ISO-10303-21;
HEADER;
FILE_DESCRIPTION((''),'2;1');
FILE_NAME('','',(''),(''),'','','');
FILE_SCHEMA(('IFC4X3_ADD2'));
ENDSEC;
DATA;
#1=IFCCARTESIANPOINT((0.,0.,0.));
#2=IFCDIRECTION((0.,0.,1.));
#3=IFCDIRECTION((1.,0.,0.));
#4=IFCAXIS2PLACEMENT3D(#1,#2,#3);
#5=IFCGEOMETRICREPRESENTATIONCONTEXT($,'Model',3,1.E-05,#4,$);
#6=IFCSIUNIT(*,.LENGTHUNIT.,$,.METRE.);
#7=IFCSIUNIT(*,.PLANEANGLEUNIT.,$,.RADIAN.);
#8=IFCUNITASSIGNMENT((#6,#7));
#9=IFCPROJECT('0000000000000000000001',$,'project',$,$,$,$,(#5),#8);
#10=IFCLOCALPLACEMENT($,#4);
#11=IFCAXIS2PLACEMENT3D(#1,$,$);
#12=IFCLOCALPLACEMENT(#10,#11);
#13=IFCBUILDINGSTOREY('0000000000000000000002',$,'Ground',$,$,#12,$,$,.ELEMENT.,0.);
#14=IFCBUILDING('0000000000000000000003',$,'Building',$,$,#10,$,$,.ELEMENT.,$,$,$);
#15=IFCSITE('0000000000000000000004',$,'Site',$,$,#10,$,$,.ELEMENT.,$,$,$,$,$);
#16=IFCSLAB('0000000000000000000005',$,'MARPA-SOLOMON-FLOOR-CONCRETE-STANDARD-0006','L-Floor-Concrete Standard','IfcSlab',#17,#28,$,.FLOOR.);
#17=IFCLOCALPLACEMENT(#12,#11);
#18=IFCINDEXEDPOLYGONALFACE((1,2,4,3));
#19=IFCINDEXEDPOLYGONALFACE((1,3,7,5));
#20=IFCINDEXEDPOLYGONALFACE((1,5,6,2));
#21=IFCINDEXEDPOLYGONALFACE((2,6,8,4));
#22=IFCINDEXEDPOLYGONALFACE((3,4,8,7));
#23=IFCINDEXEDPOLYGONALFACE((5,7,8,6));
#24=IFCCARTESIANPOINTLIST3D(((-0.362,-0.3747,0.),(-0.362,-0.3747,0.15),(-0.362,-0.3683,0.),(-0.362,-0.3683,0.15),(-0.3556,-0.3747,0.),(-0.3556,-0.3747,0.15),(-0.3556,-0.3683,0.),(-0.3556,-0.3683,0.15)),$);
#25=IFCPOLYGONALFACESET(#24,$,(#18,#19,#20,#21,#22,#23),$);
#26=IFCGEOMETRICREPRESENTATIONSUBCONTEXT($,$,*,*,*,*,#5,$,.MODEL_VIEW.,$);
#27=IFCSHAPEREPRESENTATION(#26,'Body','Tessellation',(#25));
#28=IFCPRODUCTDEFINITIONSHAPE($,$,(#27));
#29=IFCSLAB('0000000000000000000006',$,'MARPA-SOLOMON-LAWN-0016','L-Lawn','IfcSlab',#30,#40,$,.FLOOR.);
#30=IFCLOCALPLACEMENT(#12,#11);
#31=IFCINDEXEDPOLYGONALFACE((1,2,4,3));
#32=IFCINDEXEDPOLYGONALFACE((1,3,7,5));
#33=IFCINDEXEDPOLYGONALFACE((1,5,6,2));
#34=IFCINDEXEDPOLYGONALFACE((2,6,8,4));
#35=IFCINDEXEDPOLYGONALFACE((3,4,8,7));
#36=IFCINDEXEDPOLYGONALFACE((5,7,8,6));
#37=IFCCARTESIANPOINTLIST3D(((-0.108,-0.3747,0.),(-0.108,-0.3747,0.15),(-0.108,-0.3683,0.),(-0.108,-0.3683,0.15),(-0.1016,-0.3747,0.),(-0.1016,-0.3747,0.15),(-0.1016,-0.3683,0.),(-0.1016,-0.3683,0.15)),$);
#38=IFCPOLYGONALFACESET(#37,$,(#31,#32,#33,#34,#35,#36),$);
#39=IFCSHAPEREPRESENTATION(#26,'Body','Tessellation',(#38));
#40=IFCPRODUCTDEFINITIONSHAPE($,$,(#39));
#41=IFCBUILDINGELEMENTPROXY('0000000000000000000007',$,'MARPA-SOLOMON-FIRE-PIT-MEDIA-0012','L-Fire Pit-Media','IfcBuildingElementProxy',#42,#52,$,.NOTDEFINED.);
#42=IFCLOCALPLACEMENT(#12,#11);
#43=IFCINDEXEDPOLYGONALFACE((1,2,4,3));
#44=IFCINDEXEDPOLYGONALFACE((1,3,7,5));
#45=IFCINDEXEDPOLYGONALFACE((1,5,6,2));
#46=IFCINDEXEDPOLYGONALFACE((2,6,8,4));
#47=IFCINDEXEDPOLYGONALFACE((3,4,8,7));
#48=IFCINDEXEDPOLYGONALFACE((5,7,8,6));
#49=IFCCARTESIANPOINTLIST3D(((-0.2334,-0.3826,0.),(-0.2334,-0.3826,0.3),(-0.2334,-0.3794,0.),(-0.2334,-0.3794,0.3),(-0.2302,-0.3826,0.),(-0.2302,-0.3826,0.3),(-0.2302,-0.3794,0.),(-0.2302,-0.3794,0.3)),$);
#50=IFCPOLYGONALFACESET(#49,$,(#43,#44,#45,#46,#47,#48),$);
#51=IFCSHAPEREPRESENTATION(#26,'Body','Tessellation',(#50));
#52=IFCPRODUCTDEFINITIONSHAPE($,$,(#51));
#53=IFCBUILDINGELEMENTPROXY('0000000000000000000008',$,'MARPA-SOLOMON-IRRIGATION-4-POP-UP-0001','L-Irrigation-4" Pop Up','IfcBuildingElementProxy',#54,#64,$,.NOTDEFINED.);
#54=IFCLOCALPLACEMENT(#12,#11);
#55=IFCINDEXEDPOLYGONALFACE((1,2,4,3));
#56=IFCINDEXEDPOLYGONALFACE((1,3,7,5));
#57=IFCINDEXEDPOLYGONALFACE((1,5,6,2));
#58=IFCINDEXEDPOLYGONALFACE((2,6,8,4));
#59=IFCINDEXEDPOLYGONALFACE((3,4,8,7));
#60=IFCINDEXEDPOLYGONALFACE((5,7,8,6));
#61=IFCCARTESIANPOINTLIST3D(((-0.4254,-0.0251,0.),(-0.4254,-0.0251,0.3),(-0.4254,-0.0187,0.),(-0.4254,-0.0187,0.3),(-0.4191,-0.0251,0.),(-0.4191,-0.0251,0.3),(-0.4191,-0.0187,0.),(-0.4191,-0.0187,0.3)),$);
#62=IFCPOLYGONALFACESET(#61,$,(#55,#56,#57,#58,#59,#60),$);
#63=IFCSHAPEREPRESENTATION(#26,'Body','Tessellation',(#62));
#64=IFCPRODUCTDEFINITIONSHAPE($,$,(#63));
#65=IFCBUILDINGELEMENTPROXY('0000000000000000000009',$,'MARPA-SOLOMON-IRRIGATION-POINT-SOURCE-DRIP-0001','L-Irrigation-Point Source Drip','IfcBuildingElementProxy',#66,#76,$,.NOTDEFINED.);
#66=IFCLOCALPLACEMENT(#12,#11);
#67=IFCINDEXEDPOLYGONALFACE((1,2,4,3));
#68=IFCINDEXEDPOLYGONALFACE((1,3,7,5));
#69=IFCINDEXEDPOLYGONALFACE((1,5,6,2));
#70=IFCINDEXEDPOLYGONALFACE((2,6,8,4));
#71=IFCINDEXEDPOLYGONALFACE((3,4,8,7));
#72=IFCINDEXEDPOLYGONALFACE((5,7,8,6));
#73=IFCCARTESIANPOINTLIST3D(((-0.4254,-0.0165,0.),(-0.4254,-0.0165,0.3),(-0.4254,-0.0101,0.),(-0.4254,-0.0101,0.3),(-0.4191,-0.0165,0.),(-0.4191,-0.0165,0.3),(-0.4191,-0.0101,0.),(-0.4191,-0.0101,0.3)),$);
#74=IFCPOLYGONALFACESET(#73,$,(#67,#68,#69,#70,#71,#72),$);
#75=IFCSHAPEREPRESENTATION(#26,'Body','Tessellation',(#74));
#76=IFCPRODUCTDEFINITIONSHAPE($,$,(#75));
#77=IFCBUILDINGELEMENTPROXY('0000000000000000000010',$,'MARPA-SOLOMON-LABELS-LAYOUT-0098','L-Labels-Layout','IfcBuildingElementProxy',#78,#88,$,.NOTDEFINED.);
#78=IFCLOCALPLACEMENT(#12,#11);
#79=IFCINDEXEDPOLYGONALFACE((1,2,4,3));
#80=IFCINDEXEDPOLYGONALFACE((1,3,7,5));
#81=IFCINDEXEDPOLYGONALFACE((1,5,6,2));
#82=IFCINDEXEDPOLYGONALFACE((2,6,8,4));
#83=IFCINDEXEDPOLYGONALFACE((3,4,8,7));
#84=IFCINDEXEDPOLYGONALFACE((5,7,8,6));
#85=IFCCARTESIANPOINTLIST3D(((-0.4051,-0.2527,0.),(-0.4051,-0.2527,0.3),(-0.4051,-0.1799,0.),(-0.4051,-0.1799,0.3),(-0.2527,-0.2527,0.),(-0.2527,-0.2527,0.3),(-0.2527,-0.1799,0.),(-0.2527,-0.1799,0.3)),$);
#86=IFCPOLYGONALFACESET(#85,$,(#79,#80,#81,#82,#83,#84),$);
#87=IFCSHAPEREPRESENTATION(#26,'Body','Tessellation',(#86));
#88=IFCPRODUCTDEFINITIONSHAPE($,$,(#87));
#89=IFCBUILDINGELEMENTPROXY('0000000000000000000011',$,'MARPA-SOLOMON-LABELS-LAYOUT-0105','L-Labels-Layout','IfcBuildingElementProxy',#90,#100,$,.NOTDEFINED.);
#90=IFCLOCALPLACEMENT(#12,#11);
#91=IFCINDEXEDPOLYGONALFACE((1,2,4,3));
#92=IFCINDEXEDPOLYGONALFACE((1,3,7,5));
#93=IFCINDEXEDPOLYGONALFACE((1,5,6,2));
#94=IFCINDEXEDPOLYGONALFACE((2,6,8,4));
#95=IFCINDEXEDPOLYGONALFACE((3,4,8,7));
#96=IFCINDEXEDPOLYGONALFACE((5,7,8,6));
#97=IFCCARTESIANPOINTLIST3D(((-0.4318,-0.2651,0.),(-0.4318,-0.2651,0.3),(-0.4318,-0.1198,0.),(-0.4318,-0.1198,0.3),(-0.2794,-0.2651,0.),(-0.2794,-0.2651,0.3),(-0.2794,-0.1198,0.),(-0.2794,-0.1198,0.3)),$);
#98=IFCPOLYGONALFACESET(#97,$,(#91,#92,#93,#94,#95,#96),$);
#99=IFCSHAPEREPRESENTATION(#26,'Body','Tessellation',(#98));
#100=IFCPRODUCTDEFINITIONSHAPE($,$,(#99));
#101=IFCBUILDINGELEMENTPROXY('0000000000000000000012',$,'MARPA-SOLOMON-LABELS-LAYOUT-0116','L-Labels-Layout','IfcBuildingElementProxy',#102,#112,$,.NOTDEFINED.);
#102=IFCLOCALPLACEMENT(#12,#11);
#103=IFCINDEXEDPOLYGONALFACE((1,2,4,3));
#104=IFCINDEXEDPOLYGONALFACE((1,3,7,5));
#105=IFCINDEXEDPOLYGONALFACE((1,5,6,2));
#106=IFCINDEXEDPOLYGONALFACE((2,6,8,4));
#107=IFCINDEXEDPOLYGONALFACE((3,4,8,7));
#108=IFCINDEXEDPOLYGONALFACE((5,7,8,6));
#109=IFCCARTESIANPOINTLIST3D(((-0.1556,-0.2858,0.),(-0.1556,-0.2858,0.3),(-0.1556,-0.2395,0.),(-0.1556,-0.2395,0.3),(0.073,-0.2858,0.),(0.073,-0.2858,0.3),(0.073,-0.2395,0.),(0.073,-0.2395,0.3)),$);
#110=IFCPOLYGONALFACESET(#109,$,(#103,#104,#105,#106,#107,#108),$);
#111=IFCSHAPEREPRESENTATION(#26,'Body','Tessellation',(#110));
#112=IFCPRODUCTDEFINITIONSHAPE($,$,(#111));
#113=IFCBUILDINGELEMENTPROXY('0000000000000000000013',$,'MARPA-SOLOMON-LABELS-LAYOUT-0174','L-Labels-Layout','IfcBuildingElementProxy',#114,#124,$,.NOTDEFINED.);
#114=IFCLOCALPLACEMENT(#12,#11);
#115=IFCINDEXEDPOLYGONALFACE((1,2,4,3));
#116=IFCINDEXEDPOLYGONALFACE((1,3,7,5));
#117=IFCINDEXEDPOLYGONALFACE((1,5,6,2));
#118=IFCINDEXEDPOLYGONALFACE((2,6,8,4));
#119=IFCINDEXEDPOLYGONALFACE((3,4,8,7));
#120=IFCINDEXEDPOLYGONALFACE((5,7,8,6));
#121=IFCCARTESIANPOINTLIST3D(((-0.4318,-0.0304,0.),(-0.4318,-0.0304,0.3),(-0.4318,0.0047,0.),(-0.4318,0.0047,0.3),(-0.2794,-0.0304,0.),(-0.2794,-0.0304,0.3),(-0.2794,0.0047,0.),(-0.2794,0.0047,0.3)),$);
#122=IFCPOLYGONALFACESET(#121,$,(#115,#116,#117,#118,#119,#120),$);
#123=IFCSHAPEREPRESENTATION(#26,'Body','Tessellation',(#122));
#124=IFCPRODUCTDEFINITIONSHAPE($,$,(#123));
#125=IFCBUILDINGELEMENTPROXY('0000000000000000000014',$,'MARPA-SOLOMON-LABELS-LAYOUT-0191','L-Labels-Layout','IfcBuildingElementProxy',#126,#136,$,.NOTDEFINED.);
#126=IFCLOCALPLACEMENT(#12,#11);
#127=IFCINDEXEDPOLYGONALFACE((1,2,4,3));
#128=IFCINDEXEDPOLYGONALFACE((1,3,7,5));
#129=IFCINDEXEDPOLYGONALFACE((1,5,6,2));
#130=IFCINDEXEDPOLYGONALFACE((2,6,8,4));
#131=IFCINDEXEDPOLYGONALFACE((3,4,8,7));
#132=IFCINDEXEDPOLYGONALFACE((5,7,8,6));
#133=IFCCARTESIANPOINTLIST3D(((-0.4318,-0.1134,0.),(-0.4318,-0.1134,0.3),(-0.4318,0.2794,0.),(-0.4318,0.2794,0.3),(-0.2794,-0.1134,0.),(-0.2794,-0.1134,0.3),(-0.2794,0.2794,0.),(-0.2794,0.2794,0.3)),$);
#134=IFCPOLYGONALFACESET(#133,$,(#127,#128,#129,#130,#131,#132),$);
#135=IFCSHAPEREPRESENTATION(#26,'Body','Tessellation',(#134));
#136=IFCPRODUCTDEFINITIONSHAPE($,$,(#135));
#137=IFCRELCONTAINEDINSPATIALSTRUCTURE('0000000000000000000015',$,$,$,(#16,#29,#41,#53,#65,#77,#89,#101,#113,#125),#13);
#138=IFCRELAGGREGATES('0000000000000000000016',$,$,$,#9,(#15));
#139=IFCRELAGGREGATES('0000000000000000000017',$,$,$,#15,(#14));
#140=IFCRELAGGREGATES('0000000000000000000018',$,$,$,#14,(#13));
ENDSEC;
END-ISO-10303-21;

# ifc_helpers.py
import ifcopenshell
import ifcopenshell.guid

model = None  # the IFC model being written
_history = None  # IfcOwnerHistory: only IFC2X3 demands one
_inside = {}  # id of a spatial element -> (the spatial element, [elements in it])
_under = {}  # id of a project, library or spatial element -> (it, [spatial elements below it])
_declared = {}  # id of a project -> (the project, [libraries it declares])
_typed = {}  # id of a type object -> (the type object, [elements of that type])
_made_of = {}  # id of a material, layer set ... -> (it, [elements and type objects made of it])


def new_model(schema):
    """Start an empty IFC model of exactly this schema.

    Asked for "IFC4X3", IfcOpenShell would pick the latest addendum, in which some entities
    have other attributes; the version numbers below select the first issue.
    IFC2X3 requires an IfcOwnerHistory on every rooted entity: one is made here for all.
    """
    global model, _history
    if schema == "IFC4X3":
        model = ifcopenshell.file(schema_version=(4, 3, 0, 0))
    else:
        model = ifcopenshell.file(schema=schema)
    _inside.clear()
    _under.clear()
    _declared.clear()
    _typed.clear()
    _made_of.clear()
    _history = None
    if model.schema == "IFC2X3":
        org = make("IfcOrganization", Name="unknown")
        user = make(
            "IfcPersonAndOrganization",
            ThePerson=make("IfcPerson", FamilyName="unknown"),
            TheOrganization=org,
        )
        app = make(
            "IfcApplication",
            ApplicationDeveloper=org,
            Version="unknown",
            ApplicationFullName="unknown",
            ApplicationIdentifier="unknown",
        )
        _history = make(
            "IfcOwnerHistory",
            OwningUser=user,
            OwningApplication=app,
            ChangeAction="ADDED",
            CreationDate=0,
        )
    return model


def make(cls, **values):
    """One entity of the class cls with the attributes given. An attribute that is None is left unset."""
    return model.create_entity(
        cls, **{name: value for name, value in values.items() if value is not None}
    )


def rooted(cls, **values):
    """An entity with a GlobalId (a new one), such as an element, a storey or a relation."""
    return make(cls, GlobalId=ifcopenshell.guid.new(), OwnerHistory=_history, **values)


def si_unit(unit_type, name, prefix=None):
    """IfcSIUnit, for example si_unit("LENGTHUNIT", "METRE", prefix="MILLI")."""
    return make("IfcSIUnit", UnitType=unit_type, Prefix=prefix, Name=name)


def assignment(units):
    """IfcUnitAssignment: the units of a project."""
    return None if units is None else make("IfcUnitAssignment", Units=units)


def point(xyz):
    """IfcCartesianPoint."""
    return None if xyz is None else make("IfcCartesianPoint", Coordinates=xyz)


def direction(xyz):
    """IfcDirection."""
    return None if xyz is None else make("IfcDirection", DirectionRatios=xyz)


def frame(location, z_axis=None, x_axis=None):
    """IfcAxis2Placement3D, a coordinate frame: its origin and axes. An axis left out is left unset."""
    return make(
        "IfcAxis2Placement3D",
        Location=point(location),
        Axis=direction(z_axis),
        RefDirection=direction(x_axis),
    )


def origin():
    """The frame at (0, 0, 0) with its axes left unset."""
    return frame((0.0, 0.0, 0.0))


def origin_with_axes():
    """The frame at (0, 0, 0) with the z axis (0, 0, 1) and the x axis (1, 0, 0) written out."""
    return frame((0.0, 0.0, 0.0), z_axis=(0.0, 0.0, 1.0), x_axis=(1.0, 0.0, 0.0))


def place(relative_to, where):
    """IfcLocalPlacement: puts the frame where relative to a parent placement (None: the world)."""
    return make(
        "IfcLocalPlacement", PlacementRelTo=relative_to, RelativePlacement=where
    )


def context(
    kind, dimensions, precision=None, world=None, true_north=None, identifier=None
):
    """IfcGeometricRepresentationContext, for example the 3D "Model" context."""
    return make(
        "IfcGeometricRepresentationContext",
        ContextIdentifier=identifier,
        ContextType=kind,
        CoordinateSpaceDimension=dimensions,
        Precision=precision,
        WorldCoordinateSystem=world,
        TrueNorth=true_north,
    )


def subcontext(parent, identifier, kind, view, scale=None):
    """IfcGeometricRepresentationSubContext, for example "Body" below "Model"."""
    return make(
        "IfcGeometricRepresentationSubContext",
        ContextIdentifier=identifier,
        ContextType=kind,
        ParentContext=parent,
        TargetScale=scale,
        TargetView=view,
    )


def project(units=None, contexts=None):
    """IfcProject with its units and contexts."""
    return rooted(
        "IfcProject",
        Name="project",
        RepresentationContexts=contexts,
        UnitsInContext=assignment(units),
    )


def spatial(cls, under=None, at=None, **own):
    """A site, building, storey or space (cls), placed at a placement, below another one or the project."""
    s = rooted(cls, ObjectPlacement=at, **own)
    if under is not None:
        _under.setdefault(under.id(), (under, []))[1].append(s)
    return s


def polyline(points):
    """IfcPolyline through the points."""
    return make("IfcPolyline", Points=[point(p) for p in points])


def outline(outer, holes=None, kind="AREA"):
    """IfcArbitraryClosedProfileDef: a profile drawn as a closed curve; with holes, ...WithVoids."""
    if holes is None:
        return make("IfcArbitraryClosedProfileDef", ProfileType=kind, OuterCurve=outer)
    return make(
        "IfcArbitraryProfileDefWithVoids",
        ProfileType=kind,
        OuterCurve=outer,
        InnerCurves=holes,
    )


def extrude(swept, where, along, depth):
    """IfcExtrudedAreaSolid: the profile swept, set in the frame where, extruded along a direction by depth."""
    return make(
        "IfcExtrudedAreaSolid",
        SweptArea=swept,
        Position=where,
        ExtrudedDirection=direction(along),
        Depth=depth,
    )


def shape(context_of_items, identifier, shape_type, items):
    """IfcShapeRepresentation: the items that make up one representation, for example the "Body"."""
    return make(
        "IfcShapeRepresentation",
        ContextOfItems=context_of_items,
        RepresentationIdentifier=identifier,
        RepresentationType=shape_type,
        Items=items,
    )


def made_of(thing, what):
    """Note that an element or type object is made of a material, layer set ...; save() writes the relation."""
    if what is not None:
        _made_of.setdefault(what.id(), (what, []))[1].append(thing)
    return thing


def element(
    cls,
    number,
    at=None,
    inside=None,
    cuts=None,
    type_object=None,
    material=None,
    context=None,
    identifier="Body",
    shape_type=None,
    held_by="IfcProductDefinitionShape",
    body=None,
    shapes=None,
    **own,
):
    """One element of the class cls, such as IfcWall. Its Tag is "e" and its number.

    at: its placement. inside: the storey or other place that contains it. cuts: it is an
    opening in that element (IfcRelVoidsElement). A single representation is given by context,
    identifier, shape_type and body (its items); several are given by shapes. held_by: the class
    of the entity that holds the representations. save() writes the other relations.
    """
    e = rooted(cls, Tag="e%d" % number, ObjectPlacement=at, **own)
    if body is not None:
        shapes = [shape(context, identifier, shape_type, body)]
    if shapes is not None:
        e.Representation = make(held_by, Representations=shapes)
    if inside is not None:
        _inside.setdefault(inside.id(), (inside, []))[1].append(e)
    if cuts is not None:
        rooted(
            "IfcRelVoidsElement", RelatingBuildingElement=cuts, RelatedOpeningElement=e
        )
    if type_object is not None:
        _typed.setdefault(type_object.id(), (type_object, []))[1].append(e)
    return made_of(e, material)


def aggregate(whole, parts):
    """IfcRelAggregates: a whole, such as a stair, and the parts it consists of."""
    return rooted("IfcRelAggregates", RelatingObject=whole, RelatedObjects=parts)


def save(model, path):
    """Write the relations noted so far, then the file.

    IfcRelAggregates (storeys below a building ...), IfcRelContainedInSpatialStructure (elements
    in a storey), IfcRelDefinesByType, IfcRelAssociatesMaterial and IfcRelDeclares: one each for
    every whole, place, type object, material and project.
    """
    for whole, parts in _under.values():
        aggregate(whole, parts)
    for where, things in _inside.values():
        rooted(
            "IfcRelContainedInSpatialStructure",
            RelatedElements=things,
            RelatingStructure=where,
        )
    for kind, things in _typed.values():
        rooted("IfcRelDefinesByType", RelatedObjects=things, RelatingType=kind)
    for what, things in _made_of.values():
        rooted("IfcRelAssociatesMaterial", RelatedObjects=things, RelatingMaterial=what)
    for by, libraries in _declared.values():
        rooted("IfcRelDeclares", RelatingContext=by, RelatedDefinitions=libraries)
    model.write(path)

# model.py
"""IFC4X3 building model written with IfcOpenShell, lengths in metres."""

from ifc_helpers import new_model, si_unit, frame, origin, origin_with_axes, place, context, subcontext, project, spatial, polyline, outline, extrude, element, save


model = new_model("IFC4X3")

# Units and contexts
model_context = context("Model", 3, precision=1e-05, world=origin_with_axes())
sub_context = subcontext(model_context, None, None, "MODEL_VIEW")
ifc_project = project(units=[si_unit("LENGTHUNIT", "METRE"), si_unit("PLANEANGLEUNIT", "RADIAN")], contexts=[model_context])

# Site, building, storey
placement = place(None, origin_with_axes())
site = spatial("IfcSite", under=ifc_project, at=placement, Name="Site", CompositionType="ELEMENT")
building = spatial("IfcBuilding", under=site, at=placement, Name="Building", CompositionType="ELEMENT")
storey_placement = place(placement, origin())
storey = spatial("IfcBuildingStorey", under=building, at=storey_placement, Name="Ground", CompositionType="ELEMENT", Elevation=0.0)

# Slabs
for number, where, name, description in (
    (1, (-0.362, -0.3747, 0.0), "MARPA-SOLOMON-FLOOR-CONCRETE-STANDARD-0006", "L-Floor-Concrete Standard"),
    (2, (-0.108, -0.3747, 0.0), "MARPA-SOLOMON-LAWN-0016", "L-Lawn"),
):
    element("IfcSlab", number, at=place(storey_placement, frame(where)), inside=storey, Name=name, Description=description, ObjectType="IfcSlab", PredefinedType="FLOOR", context=sub_context, shape_type="SweptSolid", body=[
        extrude(outline(polyline([(0.0, 0.0064), (0.0063, 0.0064), (0.0063, 0.0), (0.0, 0.0), (0.0, 0.0064)])), origin(), (0.0, 0.0, 1.0), 0.15),
    ])

# Building element proxies
for number, where, name in (
    (3, (-0.2334, -0.3826, 0.0), "MARPA-SOLOMON-FIRE-PIT-MEDIA-0012"),
):
    element("IfcBuildingElementProxy", number, at=place(placement, frame(where)), inside=storey, Name=name, Description="L-Fire Pit-Media", ObjectType="IfcBuildingElementProxy", PredefinedType="NOTDEFINED", context=sub_context, shape_type="SweptSolid", body=[
        extrude(outline(polyline([(0.0, 0.0032), (0.0032, 0.0032), (0.0032, 0.0), (0.0, 0.0), (0.0, 0.0032)])), origin(), (0.0, 0.0, 1.0), 0.3),
    ])
for number, where, name, description in (
    (4, (-0.4254, -0.0251, 0.0), "MARPA-SOLOMON-IRRIGATION-4-POP-UP-0001", "L-Irrigation-4\" Pop Up"),
    (5, (-0.4254, -0.0165, 0.0), "MARPA-SOLOMON-IRRIGATION-POINT-SOURCE-DRIP-0001", "L-Irrigation-Point Source Drip"),
):
    element("IfcBuildingElementProxy", number, at=place(placement, frame(where)), inside=storey, Name=name, Description=description, ObjectType="IfcBuildingElementProxy", PredefinedType="NOTDEFINED", context=sub_context, shape_type="SweptSolid", body=[
        extrude(outline(polyline([(0.0, 0.0064), (0.0064, 0.0064), (0.0064, 0.0), (0.0, 0.0), (0.0, 0.0064)])), origin(), (0.0, 0.0, 1.0), 0.3),
    ])
proxy_1_placement = place(placement, frame((-0.4051, -0.2527, 0.0)))
element("IfcBuildingElementProxy", 6, at=proxy_1_placement, inside=storey, Name="MARPA-SOLOMON-LABELS-LAYOUT-0098", Description="L-Labels-Layout", ObjectType="IfcBuildingElementProxy", PredefinedType="NOTDEFINED", context=sub_context, shape_type="SweptSolid", body=[
    extrude(outline(polyline([(0.0, 0.0728), (0.1524, 0.0728), (0.1524, 0.0), (0.0, 0.0), (0.0, 0.0728)])), origin(), (0.0, 0.0, 1.0), 0.3),
])
proxy_2_placement = place(placement, frame((-0.4318, -0.2651, 0.0)))
element("IfcBuildingElementProxy", 7, at=proxy_2_placement, inside=storey, Name="MARPA-SOLOMON-LABELS-LAYOUT-0105", Description="L-Labels-Layout", ObjectType="IfcBuildingElementProxy", PredefinedType="NOTDEFINED", context=sub_context, shape_type="SweptSolid", body=[
    extrude(outline(polyline([(0.0, 0.1453), (0.1524, 0.1453), (0.1524, 0.0), (0.0, 0.0), (0.0, 0.1453)])), origin(), (0.0, 0.0, 1.0), 0.3),
])
proxy_3_placement = place(placement, frame((-0.1556, -0.2858, 0.0)))
element("IfcBuildingElementProxy", 8, at=proxy_3_placement, inside=storey, Name="MARPA-SOLOMON-LABELS-LAYOUT-0116", Description="L-Labels-Layout", ObjectType="IfcBuildingElementProxy", PredefinedType="NOTDEFINED", context=sub_context, shape_type="SweptSolid", body=[
    extrude(outline(polyline([(0.0, 0.0463), (0.2286, 0.0463), (0.2286, 0.0), (0.0, 0.0), (0.0, 0.0463)])), origin(), (0.0, 0.0, 1.0), 0.3),
])
proxy_4_placement = place(placement, frame((-0.4318, -0.0304, 0.0)))
element("IfcBuildingElementProxy", 9, at=proxy_4_placement, inside=storey, Name="MARPA-SOLOMON-LABELS-LAYOUT-0174", Description="L-Labels-Layout", ObjectType="IfcBuildingElementProxy", PredefinedType="NOTDEFINED", context=sub_context, shape_type="SweptSolid", body=[
    extrude(outline(polyline([(0.0, 0.0351), (0.1524, 0.0351), (0.1524, 0.0), (0.0, 0.0), (0.0, 0.0351)])), origin(), (0.0, 0.0, 1.0), 0.3),
])
proxy_5_placement = place(placement, frame((-0.4318, -0.1134, 0.0)))
element("IfcBuildingElementProxy", 10, at=proxy_5_placement, inside=storey, Name="MARPA-SOLOMON-LABELS-LAYOUT-0191", Description="L-Labels-Layout", ObjectType="IfcBuildingElementProxy", PredefinedType="NOTDEFINED", context=sub_context, shape_type="SweptSolid", body=[
    extrude(outline(polyline([(0.0, 0.3928), (0.1524, 0.3928), (0.1524, 0.0), (0.0, 0.0), (0.0, 0.3928)])), origin(), (0.0, 0.0, 1.0), 0.3),
])

save(model, "model.ifc")
